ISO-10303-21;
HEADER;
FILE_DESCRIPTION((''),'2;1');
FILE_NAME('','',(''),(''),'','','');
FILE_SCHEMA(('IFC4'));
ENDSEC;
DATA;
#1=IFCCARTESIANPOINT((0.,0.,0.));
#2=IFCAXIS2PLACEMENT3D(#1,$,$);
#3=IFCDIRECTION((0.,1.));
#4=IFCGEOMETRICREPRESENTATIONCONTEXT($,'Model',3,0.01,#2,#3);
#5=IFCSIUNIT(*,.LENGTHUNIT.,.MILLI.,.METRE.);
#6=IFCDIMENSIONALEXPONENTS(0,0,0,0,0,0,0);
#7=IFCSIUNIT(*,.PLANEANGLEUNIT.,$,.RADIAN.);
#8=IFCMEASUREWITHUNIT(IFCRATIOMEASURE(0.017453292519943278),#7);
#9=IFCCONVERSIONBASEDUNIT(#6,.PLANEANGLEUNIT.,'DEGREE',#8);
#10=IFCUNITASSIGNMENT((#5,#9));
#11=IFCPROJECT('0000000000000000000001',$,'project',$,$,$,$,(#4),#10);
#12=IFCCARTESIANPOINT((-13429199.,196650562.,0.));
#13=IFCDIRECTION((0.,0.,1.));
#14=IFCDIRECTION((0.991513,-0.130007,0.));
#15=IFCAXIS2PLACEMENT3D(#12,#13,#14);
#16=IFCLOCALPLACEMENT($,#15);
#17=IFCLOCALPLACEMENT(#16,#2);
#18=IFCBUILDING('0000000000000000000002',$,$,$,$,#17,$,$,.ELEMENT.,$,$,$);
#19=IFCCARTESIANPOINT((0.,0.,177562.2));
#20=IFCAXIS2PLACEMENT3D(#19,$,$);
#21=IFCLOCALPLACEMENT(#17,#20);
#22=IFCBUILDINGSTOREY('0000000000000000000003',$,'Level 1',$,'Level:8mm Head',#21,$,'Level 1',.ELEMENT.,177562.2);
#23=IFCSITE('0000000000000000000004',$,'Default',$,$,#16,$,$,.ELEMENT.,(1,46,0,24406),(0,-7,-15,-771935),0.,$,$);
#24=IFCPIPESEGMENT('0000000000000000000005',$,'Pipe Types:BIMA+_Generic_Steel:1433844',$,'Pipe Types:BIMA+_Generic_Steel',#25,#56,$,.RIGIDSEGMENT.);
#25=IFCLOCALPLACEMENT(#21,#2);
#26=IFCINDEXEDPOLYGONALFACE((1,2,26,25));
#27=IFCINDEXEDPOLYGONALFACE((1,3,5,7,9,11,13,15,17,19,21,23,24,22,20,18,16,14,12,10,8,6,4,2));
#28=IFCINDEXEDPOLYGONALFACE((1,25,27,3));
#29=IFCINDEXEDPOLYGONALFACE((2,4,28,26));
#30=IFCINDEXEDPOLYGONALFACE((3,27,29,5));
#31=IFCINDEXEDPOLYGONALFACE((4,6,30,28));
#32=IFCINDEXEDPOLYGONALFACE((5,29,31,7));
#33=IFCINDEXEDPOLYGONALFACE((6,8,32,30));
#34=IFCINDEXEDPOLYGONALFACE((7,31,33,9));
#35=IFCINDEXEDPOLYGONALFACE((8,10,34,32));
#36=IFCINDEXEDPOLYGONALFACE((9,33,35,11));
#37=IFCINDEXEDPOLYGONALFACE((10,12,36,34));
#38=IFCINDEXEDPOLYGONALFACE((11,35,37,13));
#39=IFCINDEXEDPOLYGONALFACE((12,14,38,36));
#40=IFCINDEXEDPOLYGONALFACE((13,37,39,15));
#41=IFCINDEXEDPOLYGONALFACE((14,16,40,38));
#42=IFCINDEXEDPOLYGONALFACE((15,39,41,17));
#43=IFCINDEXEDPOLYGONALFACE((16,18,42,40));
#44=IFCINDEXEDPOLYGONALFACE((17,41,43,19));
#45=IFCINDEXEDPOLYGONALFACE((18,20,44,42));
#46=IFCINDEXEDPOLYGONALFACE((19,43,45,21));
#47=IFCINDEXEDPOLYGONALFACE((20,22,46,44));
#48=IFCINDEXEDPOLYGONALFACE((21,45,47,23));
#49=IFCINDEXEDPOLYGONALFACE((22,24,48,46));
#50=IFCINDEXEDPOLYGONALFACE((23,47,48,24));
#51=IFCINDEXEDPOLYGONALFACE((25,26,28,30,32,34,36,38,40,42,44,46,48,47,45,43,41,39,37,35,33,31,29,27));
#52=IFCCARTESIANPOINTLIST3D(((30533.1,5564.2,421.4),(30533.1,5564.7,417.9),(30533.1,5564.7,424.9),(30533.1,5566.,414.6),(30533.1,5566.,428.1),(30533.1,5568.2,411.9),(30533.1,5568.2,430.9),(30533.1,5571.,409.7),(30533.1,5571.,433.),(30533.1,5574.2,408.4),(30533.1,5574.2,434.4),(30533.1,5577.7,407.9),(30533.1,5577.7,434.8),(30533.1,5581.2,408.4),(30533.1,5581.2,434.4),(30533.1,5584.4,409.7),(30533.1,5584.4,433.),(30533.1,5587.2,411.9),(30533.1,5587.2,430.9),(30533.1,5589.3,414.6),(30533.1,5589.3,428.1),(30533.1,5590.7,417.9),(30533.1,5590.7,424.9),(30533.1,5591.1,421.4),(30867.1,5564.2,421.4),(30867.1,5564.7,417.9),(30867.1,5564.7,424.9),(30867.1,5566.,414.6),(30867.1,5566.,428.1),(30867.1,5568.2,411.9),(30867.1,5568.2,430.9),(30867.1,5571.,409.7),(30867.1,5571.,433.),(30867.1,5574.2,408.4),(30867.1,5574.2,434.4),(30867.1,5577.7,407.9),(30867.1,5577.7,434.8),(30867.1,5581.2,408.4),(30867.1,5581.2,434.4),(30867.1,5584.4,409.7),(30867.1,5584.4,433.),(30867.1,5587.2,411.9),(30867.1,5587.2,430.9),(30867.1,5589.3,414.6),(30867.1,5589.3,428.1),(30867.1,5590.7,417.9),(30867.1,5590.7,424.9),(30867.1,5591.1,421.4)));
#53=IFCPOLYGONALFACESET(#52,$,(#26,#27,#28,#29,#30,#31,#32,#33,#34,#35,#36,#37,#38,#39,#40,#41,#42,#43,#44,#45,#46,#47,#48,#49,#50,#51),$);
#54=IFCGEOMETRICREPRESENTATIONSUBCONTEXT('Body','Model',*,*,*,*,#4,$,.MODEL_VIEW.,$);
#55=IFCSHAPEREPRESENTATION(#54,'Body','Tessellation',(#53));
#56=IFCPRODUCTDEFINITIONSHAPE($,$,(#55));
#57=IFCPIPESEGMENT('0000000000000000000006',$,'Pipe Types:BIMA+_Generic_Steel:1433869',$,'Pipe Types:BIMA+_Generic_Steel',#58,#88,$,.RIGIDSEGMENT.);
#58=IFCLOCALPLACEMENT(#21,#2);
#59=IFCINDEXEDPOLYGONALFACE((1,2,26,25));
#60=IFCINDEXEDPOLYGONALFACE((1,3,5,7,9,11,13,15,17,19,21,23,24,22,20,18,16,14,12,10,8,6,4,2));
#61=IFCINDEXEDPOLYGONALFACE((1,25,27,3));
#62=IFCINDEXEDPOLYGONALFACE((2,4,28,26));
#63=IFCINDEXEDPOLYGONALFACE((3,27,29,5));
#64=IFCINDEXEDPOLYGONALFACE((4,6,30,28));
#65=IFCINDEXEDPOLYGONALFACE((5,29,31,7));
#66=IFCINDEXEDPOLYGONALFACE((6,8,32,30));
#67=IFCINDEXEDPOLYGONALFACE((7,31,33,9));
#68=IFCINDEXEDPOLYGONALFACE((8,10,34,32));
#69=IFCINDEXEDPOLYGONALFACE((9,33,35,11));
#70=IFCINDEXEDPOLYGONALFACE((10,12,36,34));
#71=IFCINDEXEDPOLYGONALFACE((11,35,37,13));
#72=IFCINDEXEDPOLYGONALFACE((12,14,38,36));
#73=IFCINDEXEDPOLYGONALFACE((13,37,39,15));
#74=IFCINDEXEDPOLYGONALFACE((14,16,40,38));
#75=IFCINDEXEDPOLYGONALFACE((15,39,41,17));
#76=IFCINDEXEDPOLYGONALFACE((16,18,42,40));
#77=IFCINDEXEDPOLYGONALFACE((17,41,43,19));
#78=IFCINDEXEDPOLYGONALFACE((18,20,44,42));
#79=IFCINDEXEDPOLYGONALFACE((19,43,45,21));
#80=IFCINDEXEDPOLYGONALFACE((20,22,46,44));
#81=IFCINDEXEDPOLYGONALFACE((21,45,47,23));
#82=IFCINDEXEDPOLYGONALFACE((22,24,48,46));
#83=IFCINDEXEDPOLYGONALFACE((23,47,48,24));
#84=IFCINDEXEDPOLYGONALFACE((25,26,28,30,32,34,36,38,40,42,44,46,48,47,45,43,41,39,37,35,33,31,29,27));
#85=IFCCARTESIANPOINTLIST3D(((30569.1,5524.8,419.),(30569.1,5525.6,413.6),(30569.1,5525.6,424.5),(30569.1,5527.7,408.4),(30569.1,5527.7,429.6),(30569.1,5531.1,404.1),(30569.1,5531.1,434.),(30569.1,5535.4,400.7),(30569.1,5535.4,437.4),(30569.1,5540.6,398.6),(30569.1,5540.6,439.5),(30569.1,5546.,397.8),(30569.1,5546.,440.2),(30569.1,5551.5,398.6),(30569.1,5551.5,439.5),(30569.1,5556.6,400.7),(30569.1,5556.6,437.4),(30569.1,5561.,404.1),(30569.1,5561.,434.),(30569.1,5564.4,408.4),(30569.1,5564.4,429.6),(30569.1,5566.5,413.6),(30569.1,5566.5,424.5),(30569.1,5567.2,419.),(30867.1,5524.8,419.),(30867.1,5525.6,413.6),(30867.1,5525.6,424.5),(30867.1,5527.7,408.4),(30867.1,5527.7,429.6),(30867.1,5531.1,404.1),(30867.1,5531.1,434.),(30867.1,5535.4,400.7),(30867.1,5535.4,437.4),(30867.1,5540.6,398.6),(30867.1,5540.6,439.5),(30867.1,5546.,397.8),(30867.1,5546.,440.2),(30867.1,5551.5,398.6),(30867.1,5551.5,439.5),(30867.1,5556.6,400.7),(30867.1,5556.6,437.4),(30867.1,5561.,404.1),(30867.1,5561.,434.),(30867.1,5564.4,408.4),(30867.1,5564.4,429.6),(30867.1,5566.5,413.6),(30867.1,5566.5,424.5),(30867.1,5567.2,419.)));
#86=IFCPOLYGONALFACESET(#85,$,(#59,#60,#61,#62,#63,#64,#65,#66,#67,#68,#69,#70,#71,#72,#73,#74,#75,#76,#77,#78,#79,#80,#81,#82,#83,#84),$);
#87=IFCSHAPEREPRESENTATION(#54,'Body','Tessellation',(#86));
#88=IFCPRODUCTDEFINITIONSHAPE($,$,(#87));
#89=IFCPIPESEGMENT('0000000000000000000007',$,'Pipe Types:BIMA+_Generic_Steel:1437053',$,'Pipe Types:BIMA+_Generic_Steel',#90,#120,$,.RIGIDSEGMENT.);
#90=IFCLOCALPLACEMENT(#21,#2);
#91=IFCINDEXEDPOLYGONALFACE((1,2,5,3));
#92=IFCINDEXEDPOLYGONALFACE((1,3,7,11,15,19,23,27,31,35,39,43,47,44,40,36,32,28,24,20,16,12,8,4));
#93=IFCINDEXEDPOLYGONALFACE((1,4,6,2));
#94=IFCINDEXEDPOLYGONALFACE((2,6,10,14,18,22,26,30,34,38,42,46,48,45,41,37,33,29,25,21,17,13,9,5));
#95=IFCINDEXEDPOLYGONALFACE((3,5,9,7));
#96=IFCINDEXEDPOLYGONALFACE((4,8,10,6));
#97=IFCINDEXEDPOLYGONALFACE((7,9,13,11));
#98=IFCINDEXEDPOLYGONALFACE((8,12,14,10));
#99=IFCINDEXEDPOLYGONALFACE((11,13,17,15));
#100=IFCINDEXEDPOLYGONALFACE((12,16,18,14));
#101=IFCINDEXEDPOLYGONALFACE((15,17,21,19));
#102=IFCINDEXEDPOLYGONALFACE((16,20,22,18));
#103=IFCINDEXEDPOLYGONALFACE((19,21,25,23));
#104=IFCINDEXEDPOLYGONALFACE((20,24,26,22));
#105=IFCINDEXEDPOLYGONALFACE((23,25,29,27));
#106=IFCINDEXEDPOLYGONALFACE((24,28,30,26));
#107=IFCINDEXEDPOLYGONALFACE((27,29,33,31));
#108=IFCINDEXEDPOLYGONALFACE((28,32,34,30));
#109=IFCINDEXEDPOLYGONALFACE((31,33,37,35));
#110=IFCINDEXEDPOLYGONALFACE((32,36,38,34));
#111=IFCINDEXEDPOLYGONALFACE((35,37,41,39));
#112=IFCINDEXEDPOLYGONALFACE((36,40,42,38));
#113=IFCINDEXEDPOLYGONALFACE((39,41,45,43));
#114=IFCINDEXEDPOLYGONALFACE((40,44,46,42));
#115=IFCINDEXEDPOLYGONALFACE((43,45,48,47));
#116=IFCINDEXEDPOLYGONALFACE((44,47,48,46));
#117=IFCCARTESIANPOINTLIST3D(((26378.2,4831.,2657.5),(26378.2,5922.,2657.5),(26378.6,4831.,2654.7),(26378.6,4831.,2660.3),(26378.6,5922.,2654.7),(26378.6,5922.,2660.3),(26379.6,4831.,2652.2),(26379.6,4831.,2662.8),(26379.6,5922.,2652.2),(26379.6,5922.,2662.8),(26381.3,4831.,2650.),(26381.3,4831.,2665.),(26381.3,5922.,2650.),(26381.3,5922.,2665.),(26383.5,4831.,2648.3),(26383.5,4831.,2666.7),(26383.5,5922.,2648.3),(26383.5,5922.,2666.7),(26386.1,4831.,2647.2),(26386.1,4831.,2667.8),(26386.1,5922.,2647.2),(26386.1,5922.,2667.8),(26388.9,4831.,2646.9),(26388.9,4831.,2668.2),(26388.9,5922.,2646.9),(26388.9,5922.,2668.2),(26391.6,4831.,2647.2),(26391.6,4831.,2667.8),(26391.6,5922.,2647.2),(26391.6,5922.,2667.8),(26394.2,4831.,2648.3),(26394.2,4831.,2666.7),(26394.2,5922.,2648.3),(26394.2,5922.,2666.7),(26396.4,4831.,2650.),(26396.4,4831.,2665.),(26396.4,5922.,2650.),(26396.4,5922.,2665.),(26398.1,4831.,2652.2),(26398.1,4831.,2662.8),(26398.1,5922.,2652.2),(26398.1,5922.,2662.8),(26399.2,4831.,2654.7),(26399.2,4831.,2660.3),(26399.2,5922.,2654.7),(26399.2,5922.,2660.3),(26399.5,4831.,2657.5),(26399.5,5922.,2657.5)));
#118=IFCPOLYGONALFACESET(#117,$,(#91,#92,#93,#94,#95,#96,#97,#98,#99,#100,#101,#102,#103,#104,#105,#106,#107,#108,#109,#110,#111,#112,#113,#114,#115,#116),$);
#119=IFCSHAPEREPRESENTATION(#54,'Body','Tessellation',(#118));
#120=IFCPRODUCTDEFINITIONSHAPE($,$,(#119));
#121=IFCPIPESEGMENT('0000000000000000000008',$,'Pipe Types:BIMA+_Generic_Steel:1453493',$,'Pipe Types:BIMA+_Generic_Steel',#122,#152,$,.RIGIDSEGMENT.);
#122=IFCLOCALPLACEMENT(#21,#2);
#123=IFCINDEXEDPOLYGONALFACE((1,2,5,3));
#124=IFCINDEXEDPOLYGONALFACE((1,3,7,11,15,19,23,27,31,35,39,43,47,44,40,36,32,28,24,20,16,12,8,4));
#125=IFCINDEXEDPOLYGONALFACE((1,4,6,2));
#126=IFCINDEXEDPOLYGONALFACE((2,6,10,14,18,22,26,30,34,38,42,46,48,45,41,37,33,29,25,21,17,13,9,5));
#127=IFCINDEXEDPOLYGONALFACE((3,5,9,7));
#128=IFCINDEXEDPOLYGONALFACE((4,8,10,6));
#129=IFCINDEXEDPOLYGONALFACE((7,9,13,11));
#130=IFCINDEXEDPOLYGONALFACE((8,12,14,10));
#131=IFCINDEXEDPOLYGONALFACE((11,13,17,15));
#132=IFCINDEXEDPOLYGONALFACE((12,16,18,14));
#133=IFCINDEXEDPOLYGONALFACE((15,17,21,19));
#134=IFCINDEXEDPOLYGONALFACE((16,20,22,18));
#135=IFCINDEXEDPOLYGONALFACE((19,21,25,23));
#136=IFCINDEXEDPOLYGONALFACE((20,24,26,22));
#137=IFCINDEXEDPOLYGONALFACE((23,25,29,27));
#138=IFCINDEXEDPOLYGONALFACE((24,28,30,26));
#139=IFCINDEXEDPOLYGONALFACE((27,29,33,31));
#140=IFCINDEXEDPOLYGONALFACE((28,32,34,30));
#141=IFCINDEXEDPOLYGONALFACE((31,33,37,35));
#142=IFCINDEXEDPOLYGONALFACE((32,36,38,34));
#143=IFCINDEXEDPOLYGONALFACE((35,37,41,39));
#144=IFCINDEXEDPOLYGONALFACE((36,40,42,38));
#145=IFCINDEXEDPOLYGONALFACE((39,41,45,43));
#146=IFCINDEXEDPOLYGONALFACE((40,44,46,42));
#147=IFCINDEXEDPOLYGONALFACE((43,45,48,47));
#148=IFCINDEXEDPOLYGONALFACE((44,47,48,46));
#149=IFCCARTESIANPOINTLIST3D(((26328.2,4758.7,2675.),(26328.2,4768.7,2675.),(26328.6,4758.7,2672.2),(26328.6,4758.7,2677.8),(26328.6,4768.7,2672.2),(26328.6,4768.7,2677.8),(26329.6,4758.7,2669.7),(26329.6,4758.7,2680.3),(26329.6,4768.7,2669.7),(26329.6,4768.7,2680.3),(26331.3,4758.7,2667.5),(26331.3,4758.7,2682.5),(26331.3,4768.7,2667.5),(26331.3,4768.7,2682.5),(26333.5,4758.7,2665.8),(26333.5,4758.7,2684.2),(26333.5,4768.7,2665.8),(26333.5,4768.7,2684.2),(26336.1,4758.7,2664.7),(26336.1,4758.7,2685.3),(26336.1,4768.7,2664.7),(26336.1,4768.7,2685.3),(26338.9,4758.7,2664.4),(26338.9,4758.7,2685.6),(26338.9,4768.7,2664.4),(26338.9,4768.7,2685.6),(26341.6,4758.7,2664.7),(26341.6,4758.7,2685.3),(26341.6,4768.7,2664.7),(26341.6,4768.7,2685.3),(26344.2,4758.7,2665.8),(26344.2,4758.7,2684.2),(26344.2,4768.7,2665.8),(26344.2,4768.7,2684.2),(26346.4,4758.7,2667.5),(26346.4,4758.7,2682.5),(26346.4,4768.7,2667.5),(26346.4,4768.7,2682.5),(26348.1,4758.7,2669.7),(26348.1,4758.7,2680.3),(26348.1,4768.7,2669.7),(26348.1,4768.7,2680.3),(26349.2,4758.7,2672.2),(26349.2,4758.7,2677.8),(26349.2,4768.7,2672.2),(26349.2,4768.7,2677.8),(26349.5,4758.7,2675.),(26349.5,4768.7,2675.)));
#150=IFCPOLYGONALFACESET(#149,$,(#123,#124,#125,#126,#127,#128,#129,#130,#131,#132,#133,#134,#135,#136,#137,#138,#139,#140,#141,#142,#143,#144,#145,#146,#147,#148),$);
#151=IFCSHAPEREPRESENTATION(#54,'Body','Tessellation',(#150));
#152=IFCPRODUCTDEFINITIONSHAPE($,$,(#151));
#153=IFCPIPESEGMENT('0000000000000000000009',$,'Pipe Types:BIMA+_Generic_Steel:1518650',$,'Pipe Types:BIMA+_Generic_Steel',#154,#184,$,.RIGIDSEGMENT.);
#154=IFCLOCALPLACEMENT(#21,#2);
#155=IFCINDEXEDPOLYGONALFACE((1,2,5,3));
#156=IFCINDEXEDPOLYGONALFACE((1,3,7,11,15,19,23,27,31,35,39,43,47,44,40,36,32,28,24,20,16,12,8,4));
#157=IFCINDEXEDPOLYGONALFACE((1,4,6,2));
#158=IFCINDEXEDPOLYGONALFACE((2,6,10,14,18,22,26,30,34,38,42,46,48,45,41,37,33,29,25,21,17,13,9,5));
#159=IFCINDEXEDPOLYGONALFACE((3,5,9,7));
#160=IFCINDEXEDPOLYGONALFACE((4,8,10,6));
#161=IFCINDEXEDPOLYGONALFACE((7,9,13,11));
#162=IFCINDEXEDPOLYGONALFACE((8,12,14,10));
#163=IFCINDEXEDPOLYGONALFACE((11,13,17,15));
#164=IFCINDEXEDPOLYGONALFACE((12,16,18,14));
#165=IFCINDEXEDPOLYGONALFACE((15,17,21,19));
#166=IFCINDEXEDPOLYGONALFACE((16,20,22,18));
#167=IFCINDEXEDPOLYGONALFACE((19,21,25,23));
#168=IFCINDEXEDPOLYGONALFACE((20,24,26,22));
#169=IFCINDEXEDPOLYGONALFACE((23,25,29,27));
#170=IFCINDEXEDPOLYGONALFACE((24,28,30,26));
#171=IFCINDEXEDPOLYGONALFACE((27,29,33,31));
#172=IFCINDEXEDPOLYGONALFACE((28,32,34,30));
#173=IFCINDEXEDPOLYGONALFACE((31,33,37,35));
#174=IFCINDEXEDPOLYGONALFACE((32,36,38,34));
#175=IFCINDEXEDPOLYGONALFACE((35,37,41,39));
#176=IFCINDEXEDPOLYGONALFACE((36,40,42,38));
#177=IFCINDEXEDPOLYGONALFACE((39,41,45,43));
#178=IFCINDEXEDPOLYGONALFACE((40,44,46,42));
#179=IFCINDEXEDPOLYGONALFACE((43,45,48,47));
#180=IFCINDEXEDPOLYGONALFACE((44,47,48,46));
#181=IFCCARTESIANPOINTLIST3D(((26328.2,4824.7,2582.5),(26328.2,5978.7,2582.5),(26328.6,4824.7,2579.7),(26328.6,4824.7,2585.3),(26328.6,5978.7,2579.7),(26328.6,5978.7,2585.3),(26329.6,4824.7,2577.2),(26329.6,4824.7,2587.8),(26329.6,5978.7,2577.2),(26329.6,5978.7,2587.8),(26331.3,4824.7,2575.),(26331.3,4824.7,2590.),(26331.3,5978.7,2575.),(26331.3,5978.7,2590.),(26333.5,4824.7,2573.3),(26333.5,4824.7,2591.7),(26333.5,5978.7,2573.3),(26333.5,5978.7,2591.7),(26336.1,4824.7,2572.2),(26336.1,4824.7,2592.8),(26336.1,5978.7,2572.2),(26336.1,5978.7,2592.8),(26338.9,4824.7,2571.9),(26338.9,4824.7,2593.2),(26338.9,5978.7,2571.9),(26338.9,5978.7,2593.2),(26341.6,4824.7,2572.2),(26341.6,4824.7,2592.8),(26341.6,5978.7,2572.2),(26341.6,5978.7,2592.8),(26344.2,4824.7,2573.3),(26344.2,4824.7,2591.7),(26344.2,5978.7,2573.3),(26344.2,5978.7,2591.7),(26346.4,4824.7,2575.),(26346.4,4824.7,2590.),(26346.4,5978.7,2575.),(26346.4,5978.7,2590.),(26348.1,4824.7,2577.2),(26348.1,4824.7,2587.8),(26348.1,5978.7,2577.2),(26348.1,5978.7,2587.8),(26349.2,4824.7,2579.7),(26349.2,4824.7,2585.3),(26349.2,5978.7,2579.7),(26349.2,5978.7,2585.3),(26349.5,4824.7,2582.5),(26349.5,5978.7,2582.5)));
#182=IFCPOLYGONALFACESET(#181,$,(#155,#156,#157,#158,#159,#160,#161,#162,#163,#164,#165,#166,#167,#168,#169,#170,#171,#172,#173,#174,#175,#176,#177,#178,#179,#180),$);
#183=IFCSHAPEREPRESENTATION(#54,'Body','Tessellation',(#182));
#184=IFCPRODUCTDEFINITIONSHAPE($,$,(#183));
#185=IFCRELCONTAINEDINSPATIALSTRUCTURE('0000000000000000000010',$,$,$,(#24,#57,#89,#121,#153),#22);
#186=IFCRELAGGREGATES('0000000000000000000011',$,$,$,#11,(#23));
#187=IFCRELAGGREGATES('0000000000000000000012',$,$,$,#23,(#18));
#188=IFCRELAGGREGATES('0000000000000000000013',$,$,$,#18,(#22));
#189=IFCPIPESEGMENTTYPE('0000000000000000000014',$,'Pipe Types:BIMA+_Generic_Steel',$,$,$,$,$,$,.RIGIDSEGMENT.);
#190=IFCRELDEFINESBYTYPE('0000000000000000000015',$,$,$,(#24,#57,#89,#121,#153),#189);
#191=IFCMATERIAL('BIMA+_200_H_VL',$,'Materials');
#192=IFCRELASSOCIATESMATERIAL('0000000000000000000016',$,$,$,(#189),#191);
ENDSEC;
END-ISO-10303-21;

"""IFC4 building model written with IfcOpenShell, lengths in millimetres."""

from ifc_helpers import new_model, entity, si_unit, converted_unit, direction, frame, origin, place, context, subcontext, project, spatial, arc, indexed_curve, outline, extrude, material, type_object, element, save


model = new_model("IFC4")

# Units and contexts
model_context = context("Model", 3, precision=0.01, world=origin(), true_north=direction((0.0, 1.0)))
body_context = subcontext(model_context, "Body", "Model", "MODEL_VIEW")
ifc_project = project(units=[si_unit("LENGTHUNIT", "METRE", prefix="MILLI"), converted_unit("PLANEANGLEUNIT", "DEGREE", entity("IfcRatioMeasure", 0.017453292519943278), si_unit("PLANEANGLEUNIT", "RADIAN"), dimensions=[0, 0, 0, 0, 0, 0, 0])], contexts=[model_context])

# Site, building, storey
site_placement = place(None, frame((-13429199.0, 196650562.0, 0.0), z_axis=(0.0, 0.0, 1.0), x_axis=(0.991513, -0.130007, 0.0)))
site = spatial("IfcSite", under=ifc_project, at=site_placement, Name="Default", CompositionType="ELEMENT", RefLatitude=(1, 46, 0, 24406), RefLongitude=(0, -7, -15, -771935), RefElevation=0.0)
building_placement = place(site_placement, origin())
building = spatial("IfcBuilding", under=site, at=building_placement, CompositionType="ELEMENT")
storey_placement = place(building_placement, frame((0.0, 0.0, 177562.2)))
storey = spatial("IfcBuildingStorey", under=building, at=storey_placement, Name="Level 1", ObjectType="Level:8mm Head", LongName="Level 1", CompositionType="ELEMENT", Elevation=177562.2)

# Pipe segments
ifc_material_1 = material(Name="BIMA+_200_H_VL", Category="Materials")
pipe_segment_type_1 = type_object("IfcPipeSegmentType", Name="Pipe Types:BIMA+_Generic_Steel", PredefinedType="RIGIDSEGMENT", material=ifc_material_1)
pipe_segment_1_placement = place(storey_placement, frame((30533.1, 5562.7, 406.3)))
element("IfcPipeSegment", 1, at=pipe_segment_1_placement, inside=storey, type_object=pipe_segment_type_1, Name="Pipe Types:BIMA+_Generic_Steel:1433844", ObjectType="Pipe Types:BIMA+_Generic_Steel", PredefinedType="RIGIDSEGMENT", context=body_context, shape_type="SweptSolid", body=[
    extrude(outline(indexed_curve([(13.5, 0.0), (9.5, 9.5), (0.0, 13.5), (-9.5, 9.5), (-13.5, 0.0), (-9.5, -9.5), (0.0, -13.5), (9.5, -9.5)], segments=[arc(1, 2, 3), arc(3, 4, 5), arc(5, 6, 7), arc(7, 8, 1)], self_intersect=False)), frame((0.0, 15.0, 15.0), z_axis=(1.0, 0.0, 0.0), x_axis=(0.0, -1.0, 0.0)), (0.0, 0.0, 1.0), 334.0),
])
pipe_segment_2_placement = place(storey_placement, frame((30569.1, 5523.3, 396.2)))
element("IfcPipeSegment", 2, at=pipe_segment_2_placement, inside=storey, type_object=pipe_segment_type_1, Name="Pipe Types:BIMA+_Generic_Steel:1433869", ObjectType="Pipe Types:BIMA+_Generic_Steel", PredefinedType="RIGIDSEGMENT", context=body_context, shape_type="SweptSolid", body=[
    extrude(outline(indexed_curve([(21.2, 0.0), (15.0, 15.0), (0.0, 21.2), (-15.0, 15.0), (-21.2, 0.0), (-15.0, -15.0), (0.0, -21.2), (15.0, -15.0)], segments=[arc(1, 2, 3), arc(3, 4, 5), arc(5, 6, 7), arc(7, 8, 1)], self_intersect=False)), frame((0.0, 22.8, 22.8), z_axis=(1.0, 0.0, 0.0), x_axis=(0.0, -1.0, 0.0)), (0.0, 0.0, 1.0), 298.0),
])
pipe_segment_3_placement = place(storey_placement, frame((26376.6, 4831.0, 2645.3)))
element("IfcPipeSegment", 3, at=pipe_segment_3_placement, inside=storey, type_object=pipe_segment_type_1, Name="Pipe Types:BIMA+_Generic_Steel:1437053", ObjectType="Pipe Types:BIMA+_Generic_Steel", PredefinedType="RIGIDSEGMENT", context=body_context, shape_type="SweptSolid", body=[
    extrude(outline(indexed_curve([(10.7, 0.0), (7.5, 7.5), (0.0, 10.7), (-7.5, 7.5), (-10.7, 0.0), (-7.5, -7.5), (0.0, -10.7), (7.5, -7.5)], segments=[arc(1, 2, 3), arc(3, 4, 5), arc(5, 6, 7), arc(7, 8, 1)], self_intersect=False)), frame((12.2, 0.0, 12.2), z_axis=(0.0, 1.0, 0.0), x_axis=(1.0, 0.0, 0.0)), (0.0, 0.0, 1.0), 1091.1),
])
pipe_segment_4_placement = place(storey_placement, frame((26326.6, 4758.7, 2662.8)))
element("IfcPipeSegment", 4, at=pipe_segment_4_placement, inside=storey, type_object=pipe_segment_type_1, Name="Pipe Types:BIMA+_Generic_Steel:1453493", ObjectType="Pipe Types:BIMA+_Generic_Steel", PredefinedType="RIGIDSEGMENT", context=body_context, shape_type="SweptSolid", body=[
    extrude(outline(indexed_curve([(10.7, 0.0), (7.5, 7.5), (0.0, 10.7), (-7.5, 7.5), (-10.7, 0.0), (-7.5, -7.5), (0.0, -10.7), (7.5, -7.5)], segments=[arc(1, 2, 3), arc(3, 4, 5), arc(5, 6, 7), arc(7, 8, 1)], self_intersect=False)), frame((12.2, 0.0, 12.2), z_axis=(0.0, 1.0, 0.0), x_axis=(1.0, 0.0, 0.0)), (0.0, 0.0, 1.0), 10.0),
])
pipe_segment_5_placement = place(storey_placement, frame((26326.6, 4824.7, 2570.3)))
element("IfcPipeSegment", 5, at=pipe_segment_5_placement, inside=storey, type_object=pipe_segment_type_1, Name="Pipe Types:BIMA+_Generic_Steel:1518650", ObjectType="Pipe Types:BIMA+_Generic_Steel", PredefinedType="RIGIDSEGMENT", context=body_context, shape_type="SweptSolid", body=[
    extrude(outline(indexed_curve([(10.7, 0.0), (7.5, 7.5), (0.0, 10.6), (-7.5, 7.5), (-10.7, 0.0), (-7.5, -7.5), (0.0, -10.7), (7.5, -7.5)], segments=[arc(1, 2, 3), arc(3, 4, 5), arc(5, 6, 7), arc(7, 8, 1)], self_intersect=False)), frame((12.2, 0.0, 12.2), z_axis=(0.0, 1.0, 0.0), x_axis=(-1.0, 0.0, 0.0)), (0.0, 0.0, 1.0), 1154.0),
])

save(model, "model.ifc")
